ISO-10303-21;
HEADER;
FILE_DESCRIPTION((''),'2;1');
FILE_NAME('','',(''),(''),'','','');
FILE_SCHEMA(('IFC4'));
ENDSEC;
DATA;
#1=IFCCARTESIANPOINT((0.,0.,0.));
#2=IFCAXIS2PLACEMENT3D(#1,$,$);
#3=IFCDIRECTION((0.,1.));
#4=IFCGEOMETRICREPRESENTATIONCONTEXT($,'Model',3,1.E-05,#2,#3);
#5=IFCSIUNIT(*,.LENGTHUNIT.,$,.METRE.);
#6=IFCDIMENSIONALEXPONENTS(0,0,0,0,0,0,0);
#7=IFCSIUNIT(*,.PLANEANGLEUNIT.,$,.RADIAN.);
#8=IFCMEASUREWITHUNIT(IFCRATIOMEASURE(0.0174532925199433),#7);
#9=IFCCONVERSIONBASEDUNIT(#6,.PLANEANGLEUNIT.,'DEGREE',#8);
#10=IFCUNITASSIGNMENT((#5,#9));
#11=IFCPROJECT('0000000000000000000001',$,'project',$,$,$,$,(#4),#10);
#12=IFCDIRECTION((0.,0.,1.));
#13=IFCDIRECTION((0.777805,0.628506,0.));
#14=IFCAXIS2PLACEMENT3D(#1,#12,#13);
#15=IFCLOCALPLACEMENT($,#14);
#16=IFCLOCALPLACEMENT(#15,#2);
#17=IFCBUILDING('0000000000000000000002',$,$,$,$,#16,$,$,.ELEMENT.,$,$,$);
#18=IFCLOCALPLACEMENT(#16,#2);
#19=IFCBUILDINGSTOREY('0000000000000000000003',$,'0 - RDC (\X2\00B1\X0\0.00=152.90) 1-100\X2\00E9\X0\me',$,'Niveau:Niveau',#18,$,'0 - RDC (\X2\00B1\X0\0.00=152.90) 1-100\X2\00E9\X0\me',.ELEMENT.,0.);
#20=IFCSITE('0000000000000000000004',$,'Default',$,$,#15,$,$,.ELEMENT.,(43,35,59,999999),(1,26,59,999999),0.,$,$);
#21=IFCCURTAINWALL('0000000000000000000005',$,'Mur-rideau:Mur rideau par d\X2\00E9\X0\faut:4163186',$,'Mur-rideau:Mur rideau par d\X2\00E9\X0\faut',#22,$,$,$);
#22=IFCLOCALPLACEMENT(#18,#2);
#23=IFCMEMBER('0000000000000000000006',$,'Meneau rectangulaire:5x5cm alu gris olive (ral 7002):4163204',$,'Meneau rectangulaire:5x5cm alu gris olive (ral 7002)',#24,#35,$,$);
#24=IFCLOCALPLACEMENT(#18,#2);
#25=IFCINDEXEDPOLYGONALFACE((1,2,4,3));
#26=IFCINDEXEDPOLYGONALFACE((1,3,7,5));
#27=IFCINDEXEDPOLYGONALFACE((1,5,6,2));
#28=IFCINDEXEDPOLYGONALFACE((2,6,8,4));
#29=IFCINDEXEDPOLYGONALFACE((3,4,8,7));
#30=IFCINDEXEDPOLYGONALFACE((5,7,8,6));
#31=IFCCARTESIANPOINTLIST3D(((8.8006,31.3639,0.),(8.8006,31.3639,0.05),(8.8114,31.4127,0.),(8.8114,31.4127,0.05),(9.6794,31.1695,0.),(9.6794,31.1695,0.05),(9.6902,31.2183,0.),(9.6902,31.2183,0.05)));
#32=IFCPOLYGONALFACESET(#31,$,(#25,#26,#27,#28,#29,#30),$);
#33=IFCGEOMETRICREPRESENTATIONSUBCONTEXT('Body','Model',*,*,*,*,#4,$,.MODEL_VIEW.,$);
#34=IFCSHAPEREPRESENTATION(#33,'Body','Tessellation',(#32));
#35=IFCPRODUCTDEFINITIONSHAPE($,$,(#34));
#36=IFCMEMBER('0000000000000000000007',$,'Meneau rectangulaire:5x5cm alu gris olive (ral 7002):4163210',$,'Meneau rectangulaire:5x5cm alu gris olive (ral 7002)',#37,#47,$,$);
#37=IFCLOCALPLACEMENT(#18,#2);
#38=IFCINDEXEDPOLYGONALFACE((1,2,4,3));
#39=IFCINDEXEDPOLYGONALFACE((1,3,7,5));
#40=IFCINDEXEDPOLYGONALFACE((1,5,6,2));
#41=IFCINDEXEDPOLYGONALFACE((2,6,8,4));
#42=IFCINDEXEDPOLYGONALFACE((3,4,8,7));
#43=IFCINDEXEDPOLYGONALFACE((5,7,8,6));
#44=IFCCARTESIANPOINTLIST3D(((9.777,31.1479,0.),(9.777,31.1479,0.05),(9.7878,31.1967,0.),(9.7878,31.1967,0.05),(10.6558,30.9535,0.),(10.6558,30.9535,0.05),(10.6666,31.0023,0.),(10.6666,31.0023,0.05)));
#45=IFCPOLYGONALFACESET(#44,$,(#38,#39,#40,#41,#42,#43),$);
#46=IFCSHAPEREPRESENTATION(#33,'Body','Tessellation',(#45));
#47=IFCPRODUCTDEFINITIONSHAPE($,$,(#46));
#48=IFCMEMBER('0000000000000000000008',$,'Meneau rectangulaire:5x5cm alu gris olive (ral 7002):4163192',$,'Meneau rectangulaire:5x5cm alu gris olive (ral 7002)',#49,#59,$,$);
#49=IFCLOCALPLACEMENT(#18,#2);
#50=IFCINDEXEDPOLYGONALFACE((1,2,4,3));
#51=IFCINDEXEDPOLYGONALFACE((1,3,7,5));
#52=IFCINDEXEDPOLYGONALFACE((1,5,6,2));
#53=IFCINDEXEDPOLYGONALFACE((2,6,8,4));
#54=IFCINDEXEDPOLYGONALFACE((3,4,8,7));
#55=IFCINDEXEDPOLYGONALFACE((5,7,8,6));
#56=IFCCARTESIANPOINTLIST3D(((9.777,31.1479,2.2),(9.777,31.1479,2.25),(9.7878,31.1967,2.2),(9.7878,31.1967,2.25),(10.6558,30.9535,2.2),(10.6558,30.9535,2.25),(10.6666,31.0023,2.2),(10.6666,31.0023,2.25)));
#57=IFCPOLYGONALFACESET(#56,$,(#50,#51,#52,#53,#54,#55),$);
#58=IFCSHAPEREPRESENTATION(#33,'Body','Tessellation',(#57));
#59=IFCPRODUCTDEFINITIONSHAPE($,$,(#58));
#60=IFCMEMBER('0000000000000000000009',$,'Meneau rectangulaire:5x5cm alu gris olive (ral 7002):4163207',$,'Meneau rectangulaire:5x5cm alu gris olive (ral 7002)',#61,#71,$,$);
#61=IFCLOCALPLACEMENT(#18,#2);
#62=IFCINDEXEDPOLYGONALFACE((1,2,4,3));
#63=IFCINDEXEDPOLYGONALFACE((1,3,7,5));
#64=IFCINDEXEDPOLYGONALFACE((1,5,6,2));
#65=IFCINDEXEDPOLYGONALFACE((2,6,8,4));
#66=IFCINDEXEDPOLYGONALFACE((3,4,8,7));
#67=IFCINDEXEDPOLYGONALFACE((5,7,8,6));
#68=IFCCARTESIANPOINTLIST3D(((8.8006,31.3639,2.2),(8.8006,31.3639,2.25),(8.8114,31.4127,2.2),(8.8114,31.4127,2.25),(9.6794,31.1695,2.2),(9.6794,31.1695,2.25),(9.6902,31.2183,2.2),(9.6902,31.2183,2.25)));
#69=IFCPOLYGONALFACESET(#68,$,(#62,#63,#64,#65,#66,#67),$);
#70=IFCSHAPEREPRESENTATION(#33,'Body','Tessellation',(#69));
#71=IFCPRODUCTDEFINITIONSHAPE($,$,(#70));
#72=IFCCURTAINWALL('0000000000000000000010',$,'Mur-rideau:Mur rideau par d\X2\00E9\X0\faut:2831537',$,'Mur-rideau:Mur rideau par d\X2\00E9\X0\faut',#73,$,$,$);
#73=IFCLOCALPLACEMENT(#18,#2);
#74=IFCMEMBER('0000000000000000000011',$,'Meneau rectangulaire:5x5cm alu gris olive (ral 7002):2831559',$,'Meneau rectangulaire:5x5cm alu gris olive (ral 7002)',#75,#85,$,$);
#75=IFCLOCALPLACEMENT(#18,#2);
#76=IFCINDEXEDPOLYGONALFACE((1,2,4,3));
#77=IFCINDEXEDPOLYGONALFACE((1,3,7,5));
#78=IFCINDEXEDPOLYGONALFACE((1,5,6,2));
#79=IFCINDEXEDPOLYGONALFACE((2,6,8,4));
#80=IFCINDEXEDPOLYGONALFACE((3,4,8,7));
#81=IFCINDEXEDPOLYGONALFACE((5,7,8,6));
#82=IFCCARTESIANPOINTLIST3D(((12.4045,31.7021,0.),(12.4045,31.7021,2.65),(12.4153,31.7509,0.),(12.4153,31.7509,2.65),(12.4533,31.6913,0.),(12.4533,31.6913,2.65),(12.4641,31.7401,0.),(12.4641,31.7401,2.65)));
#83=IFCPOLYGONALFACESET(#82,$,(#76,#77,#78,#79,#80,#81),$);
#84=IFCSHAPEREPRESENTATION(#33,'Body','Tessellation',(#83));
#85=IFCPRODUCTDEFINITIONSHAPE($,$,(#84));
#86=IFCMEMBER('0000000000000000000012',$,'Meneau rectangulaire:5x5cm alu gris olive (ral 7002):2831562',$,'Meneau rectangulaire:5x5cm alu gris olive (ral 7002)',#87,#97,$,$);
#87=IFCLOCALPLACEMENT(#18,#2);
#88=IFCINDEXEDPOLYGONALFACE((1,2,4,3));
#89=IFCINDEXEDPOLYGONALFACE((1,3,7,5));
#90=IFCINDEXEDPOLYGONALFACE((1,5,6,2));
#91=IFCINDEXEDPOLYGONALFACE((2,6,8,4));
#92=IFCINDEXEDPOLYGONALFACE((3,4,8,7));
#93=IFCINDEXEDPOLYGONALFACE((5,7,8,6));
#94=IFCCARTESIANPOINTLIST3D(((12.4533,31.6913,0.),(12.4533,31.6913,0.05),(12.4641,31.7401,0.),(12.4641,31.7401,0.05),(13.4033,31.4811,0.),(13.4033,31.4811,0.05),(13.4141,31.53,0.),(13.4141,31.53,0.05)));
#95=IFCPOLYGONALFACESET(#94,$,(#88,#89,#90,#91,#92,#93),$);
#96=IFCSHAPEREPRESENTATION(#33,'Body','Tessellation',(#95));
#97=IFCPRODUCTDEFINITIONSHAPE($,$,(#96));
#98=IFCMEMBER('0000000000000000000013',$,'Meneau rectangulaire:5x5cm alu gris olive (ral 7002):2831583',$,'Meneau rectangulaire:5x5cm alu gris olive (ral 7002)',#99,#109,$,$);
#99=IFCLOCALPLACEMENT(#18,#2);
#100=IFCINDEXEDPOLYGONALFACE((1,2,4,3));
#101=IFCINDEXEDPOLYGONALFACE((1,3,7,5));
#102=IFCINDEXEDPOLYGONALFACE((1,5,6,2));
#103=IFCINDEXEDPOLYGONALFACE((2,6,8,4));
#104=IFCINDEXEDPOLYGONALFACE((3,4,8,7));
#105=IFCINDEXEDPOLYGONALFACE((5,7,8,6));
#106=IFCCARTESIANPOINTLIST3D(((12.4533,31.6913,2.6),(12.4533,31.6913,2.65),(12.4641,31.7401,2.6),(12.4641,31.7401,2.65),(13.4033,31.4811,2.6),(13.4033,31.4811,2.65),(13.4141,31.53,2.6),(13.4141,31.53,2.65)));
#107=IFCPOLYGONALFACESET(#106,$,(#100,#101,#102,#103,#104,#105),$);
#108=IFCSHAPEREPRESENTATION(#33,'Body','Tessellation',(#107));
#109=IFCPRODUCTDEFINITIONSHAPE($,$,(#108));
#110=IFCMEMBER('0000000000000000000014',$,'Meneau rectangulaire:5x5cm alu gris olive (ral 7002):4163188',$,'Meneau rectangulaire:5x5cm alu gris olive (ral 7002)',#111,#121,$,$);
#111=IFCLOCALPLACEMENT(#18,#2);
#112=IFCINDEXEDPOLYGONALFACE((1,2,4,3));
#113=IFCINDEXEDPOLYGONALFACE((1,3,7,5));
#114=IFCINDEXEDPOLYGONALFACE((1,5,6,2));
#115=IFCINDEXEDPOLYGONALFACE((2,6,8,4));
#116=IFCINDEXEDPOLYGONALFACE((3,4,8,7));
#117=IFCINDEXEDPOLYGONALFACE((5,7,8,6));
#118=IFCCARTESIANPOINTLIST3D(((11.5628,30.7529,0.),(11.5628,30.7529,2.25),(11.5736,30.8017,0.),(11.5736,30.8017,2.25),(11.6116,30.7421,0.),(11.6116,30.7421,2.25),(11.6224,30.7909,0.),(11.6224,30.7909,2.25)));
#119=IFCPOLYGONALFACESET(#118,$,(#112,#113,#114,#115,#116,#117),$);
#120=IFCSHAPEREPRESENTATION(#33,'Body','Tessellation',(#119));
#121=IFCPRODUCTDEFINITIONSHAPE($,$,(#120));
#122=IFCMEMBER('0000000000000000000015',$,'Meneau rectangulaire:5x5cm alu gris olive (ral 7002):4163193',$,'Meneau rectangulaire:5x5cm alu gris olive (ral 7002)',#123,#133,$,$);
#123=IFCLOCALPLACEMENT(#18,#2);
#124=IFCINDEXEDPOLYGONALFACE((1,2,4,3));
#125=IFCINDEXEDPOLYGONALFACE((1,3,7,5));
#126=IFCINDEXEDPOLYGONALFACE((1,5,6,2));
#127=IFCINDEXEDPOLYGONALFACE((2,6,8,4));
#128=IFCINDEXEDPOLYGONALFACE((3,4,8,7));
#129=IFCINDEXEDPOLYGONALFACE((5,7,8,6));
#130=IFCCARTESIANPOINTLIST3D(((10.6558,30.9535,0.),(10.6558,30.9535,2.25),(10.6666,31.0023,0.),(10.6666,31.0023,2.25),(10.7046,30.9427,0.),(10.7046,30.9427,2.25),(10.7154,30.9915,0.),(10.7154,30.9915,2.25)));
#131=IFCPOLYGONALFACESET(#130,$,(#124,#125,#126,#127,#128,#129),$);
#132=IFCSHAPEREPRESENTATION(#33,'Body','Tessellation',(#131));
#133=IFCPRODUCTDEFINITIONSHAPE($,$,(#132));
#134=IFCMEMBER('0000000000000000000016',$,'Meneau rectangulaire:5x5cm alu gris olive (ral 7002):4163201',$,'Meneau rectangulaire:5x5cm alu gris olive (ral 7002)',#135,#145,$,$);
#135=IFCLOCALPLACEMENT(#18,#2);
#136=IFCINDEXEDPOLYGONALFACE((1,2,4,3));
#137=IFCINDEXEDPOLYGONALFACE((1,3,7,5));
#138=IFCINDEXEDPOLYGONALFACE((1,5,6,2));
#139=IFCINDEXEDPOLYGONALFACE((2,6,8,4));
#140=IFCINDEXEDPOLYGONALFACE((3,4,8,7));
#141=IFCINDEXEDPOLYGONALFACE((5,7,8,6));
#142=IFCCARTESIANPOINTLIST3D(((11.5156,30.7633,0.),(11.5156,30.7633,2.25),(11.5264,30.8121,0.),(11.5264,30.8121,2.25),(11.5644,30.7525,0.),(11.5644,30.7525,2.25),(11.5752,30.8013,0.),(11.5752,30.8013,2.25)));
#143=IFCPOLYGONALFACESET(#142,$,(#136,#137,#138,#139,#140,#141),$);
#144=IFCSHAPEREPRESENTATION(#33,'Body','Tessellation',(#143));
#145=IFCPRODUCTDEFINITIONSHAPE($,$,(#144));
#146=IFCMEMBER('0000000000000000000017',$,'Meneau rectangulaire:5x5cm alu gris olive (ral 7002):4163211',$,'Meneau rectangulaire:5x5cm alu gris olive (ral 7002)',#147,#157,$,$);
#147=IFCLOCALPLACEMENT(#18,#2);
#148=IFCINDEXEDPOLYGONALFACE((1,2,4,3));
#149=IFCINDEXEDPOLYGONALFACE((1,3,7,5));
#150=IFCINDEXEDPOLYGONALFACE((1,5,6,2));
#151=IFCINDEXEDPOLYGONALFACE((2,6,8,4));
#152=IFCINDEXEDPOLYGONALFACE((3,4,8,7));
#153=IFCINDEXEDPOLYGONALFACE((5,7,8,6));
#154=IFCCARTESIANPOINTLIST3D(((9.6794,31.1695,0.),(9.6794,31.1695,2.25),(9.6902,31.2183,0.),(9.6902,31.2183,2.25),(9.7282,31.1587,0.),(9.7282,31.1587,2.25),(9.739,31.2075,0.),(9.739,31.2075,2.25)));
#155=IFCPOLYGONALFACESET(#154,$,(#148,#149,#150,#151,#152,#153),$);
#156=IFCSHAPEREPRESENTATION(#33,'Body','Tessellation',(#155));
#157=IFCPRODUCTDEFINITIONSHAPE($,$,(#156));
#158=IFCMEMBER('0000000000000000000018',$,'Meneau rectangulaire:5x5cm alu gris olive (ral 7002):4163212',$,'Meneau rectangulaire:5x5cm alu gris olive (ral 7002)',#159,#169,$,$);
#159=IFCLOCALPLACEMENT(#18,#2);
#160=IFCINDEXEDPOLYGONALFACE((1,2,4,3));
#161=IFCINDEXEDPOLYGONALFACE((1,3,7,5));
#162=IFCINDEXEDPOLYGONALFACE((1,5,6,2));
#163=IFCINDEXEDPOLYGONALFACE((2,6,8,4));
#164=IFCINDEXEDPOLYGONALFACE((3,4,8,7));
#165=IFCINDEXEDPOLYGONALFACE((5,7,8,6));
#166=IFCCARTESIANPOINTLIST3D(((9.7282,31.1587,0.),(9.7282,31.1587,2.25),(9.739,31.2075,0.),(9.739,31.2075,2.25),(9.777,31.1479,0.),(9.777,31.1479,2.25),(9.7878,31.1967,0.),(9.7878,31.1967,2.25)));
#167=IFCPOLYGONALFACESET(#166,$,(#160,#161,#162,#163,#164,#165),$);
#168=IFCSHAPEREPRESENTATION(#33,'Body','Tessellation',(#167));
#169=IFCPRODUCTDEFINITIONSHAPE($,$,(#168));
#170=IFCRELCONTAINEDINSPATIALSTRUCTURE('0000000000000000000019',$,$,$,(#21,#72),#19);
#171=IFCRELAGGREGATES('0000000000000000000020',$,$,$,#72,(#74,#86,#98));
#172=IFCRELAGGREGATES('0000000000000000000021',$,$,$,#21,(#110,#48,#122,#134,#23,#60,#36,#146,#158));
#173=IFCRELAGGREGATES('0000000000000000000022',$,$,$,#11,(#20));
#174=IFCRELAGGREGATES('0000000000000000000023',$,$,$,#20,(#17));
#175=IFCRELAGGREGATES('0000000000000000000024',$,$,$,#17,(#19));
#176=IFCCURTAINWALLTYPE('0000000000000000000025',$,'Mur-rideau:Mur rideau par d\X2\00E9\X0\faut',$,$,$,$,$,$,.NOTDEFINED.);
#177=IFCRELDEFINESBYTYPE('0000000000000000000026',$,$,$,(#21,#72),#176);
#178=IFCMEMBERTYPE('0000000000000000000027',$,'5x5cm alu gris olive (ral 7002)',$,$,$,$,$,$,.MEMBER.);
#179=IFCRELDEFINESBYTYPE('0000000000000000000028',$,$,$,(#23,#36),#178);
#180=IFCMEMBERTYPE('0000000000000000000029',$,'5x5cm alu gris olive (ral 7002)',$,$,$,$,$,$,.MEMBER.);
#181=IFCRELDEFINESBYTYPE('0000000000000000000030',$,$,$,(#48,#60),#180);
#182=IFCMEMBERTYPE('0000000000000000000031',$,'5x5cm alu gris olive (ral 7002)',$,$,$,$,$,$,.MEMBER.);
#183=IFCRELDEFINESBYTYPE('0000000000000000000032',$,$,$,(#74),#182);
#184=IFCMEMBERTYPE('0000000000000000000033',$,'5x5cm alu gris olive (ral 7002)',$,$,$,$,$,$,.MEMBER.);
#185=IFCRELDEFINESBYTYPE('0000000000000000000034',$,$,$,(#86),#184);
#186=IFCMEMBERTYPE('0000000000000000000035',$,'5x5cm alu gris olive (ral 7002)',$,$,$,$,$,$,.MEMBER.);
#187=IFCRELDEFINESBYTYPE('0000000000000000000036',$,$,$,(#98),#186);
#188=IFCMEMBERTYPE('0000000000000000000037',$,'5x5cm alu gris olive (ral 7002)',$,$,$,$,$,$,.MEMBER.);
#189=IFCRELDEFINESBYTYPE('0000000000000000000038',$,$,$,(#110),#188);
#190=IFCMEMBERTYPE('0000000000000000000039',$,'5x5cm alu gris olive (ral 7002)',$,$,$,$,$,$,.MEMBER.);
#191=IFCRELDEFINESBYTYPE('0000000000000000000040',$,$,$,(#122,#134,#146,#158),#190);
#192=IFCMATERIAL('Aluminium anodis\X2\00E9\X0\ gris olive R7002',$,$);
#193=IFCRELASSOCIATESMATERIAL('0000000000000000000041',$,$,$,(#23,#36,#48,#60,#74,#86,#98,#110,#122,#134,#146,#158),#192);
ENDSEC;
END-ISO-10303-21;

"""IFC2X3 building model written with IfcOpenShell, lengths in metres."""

from ifc_helpers import new_model, entity, si_unit, converted_unit, direction, frame, origin, origin_2d_with_axis, place, context, subcontext, project, spatial, rectangle, extrude, source, transform, mapped, material, type_object, type_shapes, element, aggregate, save


model = new_model("IFC2X3")

# Units and contexts
model_context = context("Model", 3, precision=1e-05, world=origin(), true_north=direction((0.0, 1.0)))
body_context = subcontext(model_context, "Body", "Model", "MODEL_VIEW")
ifc_project = project(units=[si_unit("LENGTHUNIT", "METRE"), converted_unit("PLANEANGLEUNIT", "DEGREE", entity("IfcRatioMeasure", 0.0174532925199433), si_unit("PLANEANGLEUNIT", "RADIAN"), dimensions=[0, 0, 0, 0, 0, 0, 0])], contexts=[model_context])

# Site, building, storey
site_placement = place(None, frame((0.0, 0.0, 0.0), z_axis=(0.0, 0.0, 1.0), x_axis=(0.777805, 0.628506, 0.0)))
site = spatial("IfcSite", under=ifc_project, at=site_placement, Name="Default", CompositionType="ELEMENT", RefLatitude=(43, 35, 59, 999999), RefLongitude=(1, 26, 59, 999999), RefElevation=0.0)
building_placement = place(site_placement, origin())
building = spatial("IfcBuilding", under=site, at=building_placement, CompositionType="ELEMENT")
storey_placement = place(building_placement, origin())
storey = spatial("IfcBuildingStorey", under=building, at=storey_placement, Name="0 - RDC (±0.00=152.90) 1-100éme", ObjectType="Niveau:Niveau", LongName="0 - RDC (±0.00=152.90) 1-100éme", CompositionType="ELEMENT", Elevation=0.0)

# Curtain walls, members
curtain_wall_type = type_object("IfcCurtainWallType", Name="Mur-rideau:Mur rideau par défaut", PredefinedType="NOTDEFINED")
curtain_wall_1_placement = place(storey_placement, origin())
curtain_wall_1 = element("IfcCurtainWall", 1, at=curtain_wall_1_placement, inside=storey, type_object=curtain_wall_type, Name="Mur-rideau:Mur rideau par défaut:4163186", ObjectType="Mur-rideau:Mur rideau par défaut")
ifc_material_1 = material(Name="Aluminium anodisé gris olive R7002")
member_type_1 = type_object("IfcMemberType", Name="5x5cm alu gris olive (ral 7002)", PredefinedType="MEMBER")
shared_shape_1 = source(origin(), body_context, "Body", "SweptSolid", [
    extrude(rectangle(XDim=0.05, YDim=0.05, at=origin_2d_with_axis()), frame((-0.025, 0.0, -0.9), z_axis=(0.0, 0.0, 1.0), x_axis=(0.0, -1.0, 0.0)), (0.0, 0.0, 1.0), 0.9),
])
type_shapes(member_type_1, [shared_shape_1])
member_1_placement = place(storey_placement, frame((8.806, 31.3883, 0.0), z_axis=(-0.976397, 0.215985, 0.0), x_axis=(0.0, 0.0, -1.0)))
member_1 = element("IfcMember", 2, at=member_1_placement, type_object=member_type_1, material=ifc_material_1, Name="Meneau rectangulaire:5x5cm alu gris olive (ral 7002):4163204", ObjectType="Meneau rectangulaire:5x5cm alu gris olive (ral 7002)", context=body_context, shape_type="MappedRepresentation", body=[
    mapped(shared_shape_1, transform((0.0, 0.0, 0.0), scale=1.0)),
])
member_2_placement = place(storey_placement, frame((9.7824, 31.1723, 0.0), z_axis=(-0.976397, 0.215985, 0.0), x_axis=(0.0, 0.0, -1.0)))
member_2 = element("IfcMember", 3, at=member_2_placement, type_object=member_type_1, material=ifc_material_1, Name="Meneau rectangulaire:5x5cm alu gris olive (ral 7002):4163210", ObjectType="Meneau rectangulaire:5x5cm alu gris olive (ral 7002)", context=body_context, shape_type="MappedRepresentation", body=[
    mapped(shared_shape_1, transform((0.0, 0.0, 0.0), scale=1.0)),
])
member_type_2 = type_object("IfcMemberType", Name="5x5cm alu gris olive (ral 7002)", PredefinedType="MEMBER")
shared_shape_2 = source(origin(), body_context, "Body", "SweptSolid", [
    extrude(rectangle(XDim=0.05, YDim=0.05, at=origin_2d_with_axis()), frame((-0.025, 0.0, -0.9), z_axis=(0.0, 0.0, 1.0), x_axis=(0.0, -1.0, 0.0)), (0.0, 0.0, 1.0), 0.9),
])
type_shapes(member_type_2, [shared_shape_2])
member_3_placement = place(storey_placement, frame((10.6612, 30.9779, 2.25), z_axis=(0.976397, -0.215985, 0.0), x_axis=(0.0, 0.0, 1.0)))
member_3 = element("IfcMember", 4, at=member_3_placement, type_object=member_type_2, material=ifc_material_1, Name="Meneau rectangulaire:5x5cm alu gris olive (ral 7002):4163192", ObjectType="Meneau rectangulaire:5x5cm alu gris olive (ral 7002)", context=body_context, shape_type="MappedRepresentation", body=[
    mapped(shared_shape_2, transform((0.0, 0.0, 0.0), scale=1.0)),
])
member_4_placement = place(storey_placement, frame((9.6848, 31.1939, 2.25), z_axis=(0.976397, -0.215985, 0.0), x_axis=(0.0, 0.0, 1.0)))
member_4 = element("IfcMember", 5, at=member_4_placement, type_object=member_type_2, material=ifc_material_1, Name="Meneau rectangulaire:5x5cm alu gris olive (ral 7002):4163207", ObjectType="Meneau rectangulaire:5x5cm alu gris olive (ral 7002)", context=body_context, shape_type="MappedRepresentation", body=[
    mapped(shared_shape_2, transform((0.0, 0.0, 0.0), scale=1.0)),
])
curtain_wall_2_placement = place(storey_placement, origin())
curtain_wall_2 = element("IfcCurtainWall", 6, at=curtain_wall_2_placement, inside=storey, type_object=curtain_wall_type, Name="Mur-rideau:Mur rideau par défaut:2831537", ObjectType="Mur-rideau:Mur rideau par défaut")
member_type_3 = type_object("IfcMemberType", Name="5x5cm alu gris olive (ral 7002)", PredefinedType="MEMBER")
shared_shape_3 = source(origin(), body_context, "Body", "SweptSolid", [
    extrude(rectangle(XDim=0.05, YDim=0.05, at=origin_2d_with_axis()), frame((-0.025, 0.0, -2.65), z_axis=(0.0, 0.0, 1.0), x_axis=(0.0, -1.0, 0.0)), (0.0, 0.0, 1.0), 2.65),
])
type_shapes(member_type_3, [shared_shape_3])
member_5_placement = place(storey_placement, frame((12.4099, 31.7265, 2.65), z_axis=(0.0, 0.0, 1.0), x_axis=(-0.976397, 0.215985, 0.0)))
member_5 = element("IfcMember", 7, at=member_5_placement, type_object=member_type_3, material=ifc_material_1, Name="Meneau rectangulaire:5x5cm alu gris olive (ral 7002):2831559", ObjectType="Meneau rectangulaire:5x5cm alu gris olive (ral 7002)", context=body_context, shape_type="MappedRepresentation", body=[
    mapped(shared_shape_3, transform((0.0, 0.0, 0.0), scale=1.0)),
])
member_type_4 = type_object("IfcMemberType", Name="5x5cm alu gris olive (ral 7002)", PredefinedType="MEMBER")
shared_shape_4 = source(origin(), body_context, "Body", "SweptSolid", [
    extrude(rectangle(XDim=0.05, YDim=0.05, at=origin_2d_with_axis()), frame((-0.025, 0.0, -0.9729), z_axis=(0.0, 0.0, 1.0), x_axis=(0.0, -1.0, 0.0)), (0.0, 0.0, 1.0), 0.9729),
])
type_shapes(member_type_4, [shared_shape_4])
member_6_placement = place(storey_placement, frame((12.4587, 31.7157, 0.0), z_axis=(-0.976397, 0.215985, 0.0), x_axis=(0.0, 0.0, -1.0)))
member_6 = element("IfcMember", 8, at=member_6_placement, type_object=member_type_4, material=ifc_material_1, Name="Meneau rectangulaire:5x5cm alu gris olive (ral 7002):2831562", ObjectType="Meneau rectangulaire:5x5cm alu gris olive (ral 7002)", context=body_context, shape_type="MappedRepresentation", body=[
    mapped(shared_shape_4, transform((0.0, 0.0, 0.0), scale=1.0)),
])
member_type_5 = type_object("IfcMemberType", Name="5x5cm alu gris olive (ral 7002)", PredefinedType="MEMBER")
shared_shape_5 = source(origin(), body_context, "Body", "SweptSolid", [
    extrude(rectangle(XDim=0.05, YDim=0.05, at=origin_2d_with_axis()), frame((-0.025, 0.0, -0.9729), z_axis=(0.0, 0.0, 1.0), x_axis=(0.0, -1.0, 0.0)), (0.0, 0.0, 1.0), 0.9729),
])
type_shapes(member_type_5, [shared_shape_5])
member_7_placement = place(storey_placement, frame((13.4087, 31.5055, 2.65), z_axis=(0.976397, -0.215985, 0.0), x_axis=(0.0, 0.0, 1.0)))
member_7 = element("IfcMember", 9, at=member_7_placement, type_object=member_type_5, material=ifc_material_1, Name="Meneau rectangulaire:5x5cm alu gris olive (ral 7002):2831583", ObjectType="Meneau rectangulaire:5x5cm alu gris olive (ral 7002)", context=body_context, shape_type="MappedRepresentation", body=[
    mapped(shared_shape_5, transform((0.0, 0.0, 0.0), scale=1.0)),
])

# Members
member_type_6 = type_object("IfcMemberType", Name="5x5cm alu gris olive (ral 7002)", PredefinedType="MEMBER")
shared_shape_6 = source(origin(), body_context, "Body", "SweptSolid", [
    extrude(rectangle(XDim=0.05, YDim=0.05, at=origin_2d_with_axis()), frame((-0.025, 0.0, -2.25), z_axis=(0.0, 0.0, 1.0), x_axis=(0.0, -1.0, 0.0)), (0.0, 0.0, 1.0), 2.25),
])
type_shapes(member_type_6, [shared_shape_6])
member_8_placement = place(storey_placement, frame((11.617, 30.7665, 0.0), z_axis=(0.0, 0.0, -1.0), x_axis=(0.976397, -0.215985, 0.0)))
member_8 = element("IfcMember", 10, at=member_8_placement, type_object=member_type_6, material=ifc_material_1, Name="Meneau rectangulaire:5x5cm alu gris olive (ral 7002):4163188", ObjectType="Meneau rectangulaire:5x5cm alu gris olive (ral 7002)", context=body_context, shape_type="MappedRepresentation", body=[
    mapped(shared_shape_6, transform((0.0, 0.0, 0.0), scale=1.0)),
])
member_type_7 = type_object("IfcMemberType", Name="5x5cm alu gris olive (ral 7002)", PredefinedType="MEMBER")
shared_shape_7 = source(origin(), body_context, "Body", "SweptSolid", [
    extrude(rectangle(XDim=0.05, YDim=0.05, at=origin_2d_with_axis()), frame((0.0, 0.0, -2.25), z_axis=(0.0, 0.0, 1.0), x_axis=(0.0, -1.0, 0.0)), (0.0, 0.0, 1.0), 2.25),
])
type_shapes(member_type_7, [shared_shape_7])
member_9_placement = place(storey_placement, frame((10.6856, 30.9725, 0.0), z_axis=(0.0, 0.0, -1.0), x_axis=(0.976397, -0.215985, 0.0)))
member_9 = element("IfcMember", 11, at=member_9_placement, type_object=member_type_7, material=ifc_material_1, Name="Meneau rectangulaire:5x5cm alu gris olive (ral 7002):4163193", ObjectType="Meneau rectangulaire:5x5cm alu gris olive (ral 7002)", context=body_context, shape_type="MappedRepresentation", body=[
    mapped(shared_shape_7, transform((0.0, 0.0, 0.0), scale=1.0)),
])
member_10_placement = place(storey_placement, frame((11.5454, 30.7823, 0.0), z_axis=(0.0, 0.0, -1.0), x_axis=(0.976397, -0.215985, 0.0)))
member_10 = element("IfcMember", 12, at=member_10_placement, type_object=member_type_7, material=ifc_material_1, Name="Meneau rectangulaire:5x5cm alu gris olive (ral 7002):4163201", ObjectType="Meneau rectangulaire:5x5cm alu gris olive (ral 7002)", context=body_context, shape_type="MappedRepresentation", body=[
    mapped(shared_shape_7, transform((0.0, 0.0, 0.0), scale=1.0)),
])
member_11_placement = place(storey_placement, frame((9.7092, 31.1885, 0.0), z_axis=(0.0, 0.0, -1.0), x_axis=(0.976397, -0.215985, 0.0)))
member_11 = element("IfcMember", 13, at=member_11_placement, type_object=member_type_7, material=ifc_material_1, Name="Meneau rectangulaire:5x5cm alu gris olive (ral 7002):4163211", ObjectType="Meneau rectangulaire:5x5cm alu gris olive (ral 7002)", context=body_context, shape_type="MappedRepresentation", body=[
    mapped(shared_shape_7, transform((0.0, 0.0, 0.0), scale=1.0)),
])
member_12_placement = place(storey_placement, frame((9.758, 31.1777, 0.0), z_axis=(0.0, 0.0, -1.0), x_axis=(0.976397, -0.215985, 0.0)))
member_12 = element("IfcMember", 14, at=member_12_placement, type_object=member_type_7, material=ifc_material_1, Name="Meneau rectangulaire:5x5cm alu gris olive (ral 7002):4163212", ObjectType="Meneau rectangulaire:5x5cm alu gris olive (ral 7002)", context=body_context, shape_type="MappedRepresentation", body=[
    mapped(shared_shape_7, transform((0.0, 0.0, 0.0), scale=1.0)),
])

aggregate(curtain_wall_2, [member_5, member_6, member_7])
aggregate(curtain_wall_1, [member_8, member_3, member_9, member_10, member_1, member_4, member_2, member_11, member_12])

save(model, "model.ifc")
